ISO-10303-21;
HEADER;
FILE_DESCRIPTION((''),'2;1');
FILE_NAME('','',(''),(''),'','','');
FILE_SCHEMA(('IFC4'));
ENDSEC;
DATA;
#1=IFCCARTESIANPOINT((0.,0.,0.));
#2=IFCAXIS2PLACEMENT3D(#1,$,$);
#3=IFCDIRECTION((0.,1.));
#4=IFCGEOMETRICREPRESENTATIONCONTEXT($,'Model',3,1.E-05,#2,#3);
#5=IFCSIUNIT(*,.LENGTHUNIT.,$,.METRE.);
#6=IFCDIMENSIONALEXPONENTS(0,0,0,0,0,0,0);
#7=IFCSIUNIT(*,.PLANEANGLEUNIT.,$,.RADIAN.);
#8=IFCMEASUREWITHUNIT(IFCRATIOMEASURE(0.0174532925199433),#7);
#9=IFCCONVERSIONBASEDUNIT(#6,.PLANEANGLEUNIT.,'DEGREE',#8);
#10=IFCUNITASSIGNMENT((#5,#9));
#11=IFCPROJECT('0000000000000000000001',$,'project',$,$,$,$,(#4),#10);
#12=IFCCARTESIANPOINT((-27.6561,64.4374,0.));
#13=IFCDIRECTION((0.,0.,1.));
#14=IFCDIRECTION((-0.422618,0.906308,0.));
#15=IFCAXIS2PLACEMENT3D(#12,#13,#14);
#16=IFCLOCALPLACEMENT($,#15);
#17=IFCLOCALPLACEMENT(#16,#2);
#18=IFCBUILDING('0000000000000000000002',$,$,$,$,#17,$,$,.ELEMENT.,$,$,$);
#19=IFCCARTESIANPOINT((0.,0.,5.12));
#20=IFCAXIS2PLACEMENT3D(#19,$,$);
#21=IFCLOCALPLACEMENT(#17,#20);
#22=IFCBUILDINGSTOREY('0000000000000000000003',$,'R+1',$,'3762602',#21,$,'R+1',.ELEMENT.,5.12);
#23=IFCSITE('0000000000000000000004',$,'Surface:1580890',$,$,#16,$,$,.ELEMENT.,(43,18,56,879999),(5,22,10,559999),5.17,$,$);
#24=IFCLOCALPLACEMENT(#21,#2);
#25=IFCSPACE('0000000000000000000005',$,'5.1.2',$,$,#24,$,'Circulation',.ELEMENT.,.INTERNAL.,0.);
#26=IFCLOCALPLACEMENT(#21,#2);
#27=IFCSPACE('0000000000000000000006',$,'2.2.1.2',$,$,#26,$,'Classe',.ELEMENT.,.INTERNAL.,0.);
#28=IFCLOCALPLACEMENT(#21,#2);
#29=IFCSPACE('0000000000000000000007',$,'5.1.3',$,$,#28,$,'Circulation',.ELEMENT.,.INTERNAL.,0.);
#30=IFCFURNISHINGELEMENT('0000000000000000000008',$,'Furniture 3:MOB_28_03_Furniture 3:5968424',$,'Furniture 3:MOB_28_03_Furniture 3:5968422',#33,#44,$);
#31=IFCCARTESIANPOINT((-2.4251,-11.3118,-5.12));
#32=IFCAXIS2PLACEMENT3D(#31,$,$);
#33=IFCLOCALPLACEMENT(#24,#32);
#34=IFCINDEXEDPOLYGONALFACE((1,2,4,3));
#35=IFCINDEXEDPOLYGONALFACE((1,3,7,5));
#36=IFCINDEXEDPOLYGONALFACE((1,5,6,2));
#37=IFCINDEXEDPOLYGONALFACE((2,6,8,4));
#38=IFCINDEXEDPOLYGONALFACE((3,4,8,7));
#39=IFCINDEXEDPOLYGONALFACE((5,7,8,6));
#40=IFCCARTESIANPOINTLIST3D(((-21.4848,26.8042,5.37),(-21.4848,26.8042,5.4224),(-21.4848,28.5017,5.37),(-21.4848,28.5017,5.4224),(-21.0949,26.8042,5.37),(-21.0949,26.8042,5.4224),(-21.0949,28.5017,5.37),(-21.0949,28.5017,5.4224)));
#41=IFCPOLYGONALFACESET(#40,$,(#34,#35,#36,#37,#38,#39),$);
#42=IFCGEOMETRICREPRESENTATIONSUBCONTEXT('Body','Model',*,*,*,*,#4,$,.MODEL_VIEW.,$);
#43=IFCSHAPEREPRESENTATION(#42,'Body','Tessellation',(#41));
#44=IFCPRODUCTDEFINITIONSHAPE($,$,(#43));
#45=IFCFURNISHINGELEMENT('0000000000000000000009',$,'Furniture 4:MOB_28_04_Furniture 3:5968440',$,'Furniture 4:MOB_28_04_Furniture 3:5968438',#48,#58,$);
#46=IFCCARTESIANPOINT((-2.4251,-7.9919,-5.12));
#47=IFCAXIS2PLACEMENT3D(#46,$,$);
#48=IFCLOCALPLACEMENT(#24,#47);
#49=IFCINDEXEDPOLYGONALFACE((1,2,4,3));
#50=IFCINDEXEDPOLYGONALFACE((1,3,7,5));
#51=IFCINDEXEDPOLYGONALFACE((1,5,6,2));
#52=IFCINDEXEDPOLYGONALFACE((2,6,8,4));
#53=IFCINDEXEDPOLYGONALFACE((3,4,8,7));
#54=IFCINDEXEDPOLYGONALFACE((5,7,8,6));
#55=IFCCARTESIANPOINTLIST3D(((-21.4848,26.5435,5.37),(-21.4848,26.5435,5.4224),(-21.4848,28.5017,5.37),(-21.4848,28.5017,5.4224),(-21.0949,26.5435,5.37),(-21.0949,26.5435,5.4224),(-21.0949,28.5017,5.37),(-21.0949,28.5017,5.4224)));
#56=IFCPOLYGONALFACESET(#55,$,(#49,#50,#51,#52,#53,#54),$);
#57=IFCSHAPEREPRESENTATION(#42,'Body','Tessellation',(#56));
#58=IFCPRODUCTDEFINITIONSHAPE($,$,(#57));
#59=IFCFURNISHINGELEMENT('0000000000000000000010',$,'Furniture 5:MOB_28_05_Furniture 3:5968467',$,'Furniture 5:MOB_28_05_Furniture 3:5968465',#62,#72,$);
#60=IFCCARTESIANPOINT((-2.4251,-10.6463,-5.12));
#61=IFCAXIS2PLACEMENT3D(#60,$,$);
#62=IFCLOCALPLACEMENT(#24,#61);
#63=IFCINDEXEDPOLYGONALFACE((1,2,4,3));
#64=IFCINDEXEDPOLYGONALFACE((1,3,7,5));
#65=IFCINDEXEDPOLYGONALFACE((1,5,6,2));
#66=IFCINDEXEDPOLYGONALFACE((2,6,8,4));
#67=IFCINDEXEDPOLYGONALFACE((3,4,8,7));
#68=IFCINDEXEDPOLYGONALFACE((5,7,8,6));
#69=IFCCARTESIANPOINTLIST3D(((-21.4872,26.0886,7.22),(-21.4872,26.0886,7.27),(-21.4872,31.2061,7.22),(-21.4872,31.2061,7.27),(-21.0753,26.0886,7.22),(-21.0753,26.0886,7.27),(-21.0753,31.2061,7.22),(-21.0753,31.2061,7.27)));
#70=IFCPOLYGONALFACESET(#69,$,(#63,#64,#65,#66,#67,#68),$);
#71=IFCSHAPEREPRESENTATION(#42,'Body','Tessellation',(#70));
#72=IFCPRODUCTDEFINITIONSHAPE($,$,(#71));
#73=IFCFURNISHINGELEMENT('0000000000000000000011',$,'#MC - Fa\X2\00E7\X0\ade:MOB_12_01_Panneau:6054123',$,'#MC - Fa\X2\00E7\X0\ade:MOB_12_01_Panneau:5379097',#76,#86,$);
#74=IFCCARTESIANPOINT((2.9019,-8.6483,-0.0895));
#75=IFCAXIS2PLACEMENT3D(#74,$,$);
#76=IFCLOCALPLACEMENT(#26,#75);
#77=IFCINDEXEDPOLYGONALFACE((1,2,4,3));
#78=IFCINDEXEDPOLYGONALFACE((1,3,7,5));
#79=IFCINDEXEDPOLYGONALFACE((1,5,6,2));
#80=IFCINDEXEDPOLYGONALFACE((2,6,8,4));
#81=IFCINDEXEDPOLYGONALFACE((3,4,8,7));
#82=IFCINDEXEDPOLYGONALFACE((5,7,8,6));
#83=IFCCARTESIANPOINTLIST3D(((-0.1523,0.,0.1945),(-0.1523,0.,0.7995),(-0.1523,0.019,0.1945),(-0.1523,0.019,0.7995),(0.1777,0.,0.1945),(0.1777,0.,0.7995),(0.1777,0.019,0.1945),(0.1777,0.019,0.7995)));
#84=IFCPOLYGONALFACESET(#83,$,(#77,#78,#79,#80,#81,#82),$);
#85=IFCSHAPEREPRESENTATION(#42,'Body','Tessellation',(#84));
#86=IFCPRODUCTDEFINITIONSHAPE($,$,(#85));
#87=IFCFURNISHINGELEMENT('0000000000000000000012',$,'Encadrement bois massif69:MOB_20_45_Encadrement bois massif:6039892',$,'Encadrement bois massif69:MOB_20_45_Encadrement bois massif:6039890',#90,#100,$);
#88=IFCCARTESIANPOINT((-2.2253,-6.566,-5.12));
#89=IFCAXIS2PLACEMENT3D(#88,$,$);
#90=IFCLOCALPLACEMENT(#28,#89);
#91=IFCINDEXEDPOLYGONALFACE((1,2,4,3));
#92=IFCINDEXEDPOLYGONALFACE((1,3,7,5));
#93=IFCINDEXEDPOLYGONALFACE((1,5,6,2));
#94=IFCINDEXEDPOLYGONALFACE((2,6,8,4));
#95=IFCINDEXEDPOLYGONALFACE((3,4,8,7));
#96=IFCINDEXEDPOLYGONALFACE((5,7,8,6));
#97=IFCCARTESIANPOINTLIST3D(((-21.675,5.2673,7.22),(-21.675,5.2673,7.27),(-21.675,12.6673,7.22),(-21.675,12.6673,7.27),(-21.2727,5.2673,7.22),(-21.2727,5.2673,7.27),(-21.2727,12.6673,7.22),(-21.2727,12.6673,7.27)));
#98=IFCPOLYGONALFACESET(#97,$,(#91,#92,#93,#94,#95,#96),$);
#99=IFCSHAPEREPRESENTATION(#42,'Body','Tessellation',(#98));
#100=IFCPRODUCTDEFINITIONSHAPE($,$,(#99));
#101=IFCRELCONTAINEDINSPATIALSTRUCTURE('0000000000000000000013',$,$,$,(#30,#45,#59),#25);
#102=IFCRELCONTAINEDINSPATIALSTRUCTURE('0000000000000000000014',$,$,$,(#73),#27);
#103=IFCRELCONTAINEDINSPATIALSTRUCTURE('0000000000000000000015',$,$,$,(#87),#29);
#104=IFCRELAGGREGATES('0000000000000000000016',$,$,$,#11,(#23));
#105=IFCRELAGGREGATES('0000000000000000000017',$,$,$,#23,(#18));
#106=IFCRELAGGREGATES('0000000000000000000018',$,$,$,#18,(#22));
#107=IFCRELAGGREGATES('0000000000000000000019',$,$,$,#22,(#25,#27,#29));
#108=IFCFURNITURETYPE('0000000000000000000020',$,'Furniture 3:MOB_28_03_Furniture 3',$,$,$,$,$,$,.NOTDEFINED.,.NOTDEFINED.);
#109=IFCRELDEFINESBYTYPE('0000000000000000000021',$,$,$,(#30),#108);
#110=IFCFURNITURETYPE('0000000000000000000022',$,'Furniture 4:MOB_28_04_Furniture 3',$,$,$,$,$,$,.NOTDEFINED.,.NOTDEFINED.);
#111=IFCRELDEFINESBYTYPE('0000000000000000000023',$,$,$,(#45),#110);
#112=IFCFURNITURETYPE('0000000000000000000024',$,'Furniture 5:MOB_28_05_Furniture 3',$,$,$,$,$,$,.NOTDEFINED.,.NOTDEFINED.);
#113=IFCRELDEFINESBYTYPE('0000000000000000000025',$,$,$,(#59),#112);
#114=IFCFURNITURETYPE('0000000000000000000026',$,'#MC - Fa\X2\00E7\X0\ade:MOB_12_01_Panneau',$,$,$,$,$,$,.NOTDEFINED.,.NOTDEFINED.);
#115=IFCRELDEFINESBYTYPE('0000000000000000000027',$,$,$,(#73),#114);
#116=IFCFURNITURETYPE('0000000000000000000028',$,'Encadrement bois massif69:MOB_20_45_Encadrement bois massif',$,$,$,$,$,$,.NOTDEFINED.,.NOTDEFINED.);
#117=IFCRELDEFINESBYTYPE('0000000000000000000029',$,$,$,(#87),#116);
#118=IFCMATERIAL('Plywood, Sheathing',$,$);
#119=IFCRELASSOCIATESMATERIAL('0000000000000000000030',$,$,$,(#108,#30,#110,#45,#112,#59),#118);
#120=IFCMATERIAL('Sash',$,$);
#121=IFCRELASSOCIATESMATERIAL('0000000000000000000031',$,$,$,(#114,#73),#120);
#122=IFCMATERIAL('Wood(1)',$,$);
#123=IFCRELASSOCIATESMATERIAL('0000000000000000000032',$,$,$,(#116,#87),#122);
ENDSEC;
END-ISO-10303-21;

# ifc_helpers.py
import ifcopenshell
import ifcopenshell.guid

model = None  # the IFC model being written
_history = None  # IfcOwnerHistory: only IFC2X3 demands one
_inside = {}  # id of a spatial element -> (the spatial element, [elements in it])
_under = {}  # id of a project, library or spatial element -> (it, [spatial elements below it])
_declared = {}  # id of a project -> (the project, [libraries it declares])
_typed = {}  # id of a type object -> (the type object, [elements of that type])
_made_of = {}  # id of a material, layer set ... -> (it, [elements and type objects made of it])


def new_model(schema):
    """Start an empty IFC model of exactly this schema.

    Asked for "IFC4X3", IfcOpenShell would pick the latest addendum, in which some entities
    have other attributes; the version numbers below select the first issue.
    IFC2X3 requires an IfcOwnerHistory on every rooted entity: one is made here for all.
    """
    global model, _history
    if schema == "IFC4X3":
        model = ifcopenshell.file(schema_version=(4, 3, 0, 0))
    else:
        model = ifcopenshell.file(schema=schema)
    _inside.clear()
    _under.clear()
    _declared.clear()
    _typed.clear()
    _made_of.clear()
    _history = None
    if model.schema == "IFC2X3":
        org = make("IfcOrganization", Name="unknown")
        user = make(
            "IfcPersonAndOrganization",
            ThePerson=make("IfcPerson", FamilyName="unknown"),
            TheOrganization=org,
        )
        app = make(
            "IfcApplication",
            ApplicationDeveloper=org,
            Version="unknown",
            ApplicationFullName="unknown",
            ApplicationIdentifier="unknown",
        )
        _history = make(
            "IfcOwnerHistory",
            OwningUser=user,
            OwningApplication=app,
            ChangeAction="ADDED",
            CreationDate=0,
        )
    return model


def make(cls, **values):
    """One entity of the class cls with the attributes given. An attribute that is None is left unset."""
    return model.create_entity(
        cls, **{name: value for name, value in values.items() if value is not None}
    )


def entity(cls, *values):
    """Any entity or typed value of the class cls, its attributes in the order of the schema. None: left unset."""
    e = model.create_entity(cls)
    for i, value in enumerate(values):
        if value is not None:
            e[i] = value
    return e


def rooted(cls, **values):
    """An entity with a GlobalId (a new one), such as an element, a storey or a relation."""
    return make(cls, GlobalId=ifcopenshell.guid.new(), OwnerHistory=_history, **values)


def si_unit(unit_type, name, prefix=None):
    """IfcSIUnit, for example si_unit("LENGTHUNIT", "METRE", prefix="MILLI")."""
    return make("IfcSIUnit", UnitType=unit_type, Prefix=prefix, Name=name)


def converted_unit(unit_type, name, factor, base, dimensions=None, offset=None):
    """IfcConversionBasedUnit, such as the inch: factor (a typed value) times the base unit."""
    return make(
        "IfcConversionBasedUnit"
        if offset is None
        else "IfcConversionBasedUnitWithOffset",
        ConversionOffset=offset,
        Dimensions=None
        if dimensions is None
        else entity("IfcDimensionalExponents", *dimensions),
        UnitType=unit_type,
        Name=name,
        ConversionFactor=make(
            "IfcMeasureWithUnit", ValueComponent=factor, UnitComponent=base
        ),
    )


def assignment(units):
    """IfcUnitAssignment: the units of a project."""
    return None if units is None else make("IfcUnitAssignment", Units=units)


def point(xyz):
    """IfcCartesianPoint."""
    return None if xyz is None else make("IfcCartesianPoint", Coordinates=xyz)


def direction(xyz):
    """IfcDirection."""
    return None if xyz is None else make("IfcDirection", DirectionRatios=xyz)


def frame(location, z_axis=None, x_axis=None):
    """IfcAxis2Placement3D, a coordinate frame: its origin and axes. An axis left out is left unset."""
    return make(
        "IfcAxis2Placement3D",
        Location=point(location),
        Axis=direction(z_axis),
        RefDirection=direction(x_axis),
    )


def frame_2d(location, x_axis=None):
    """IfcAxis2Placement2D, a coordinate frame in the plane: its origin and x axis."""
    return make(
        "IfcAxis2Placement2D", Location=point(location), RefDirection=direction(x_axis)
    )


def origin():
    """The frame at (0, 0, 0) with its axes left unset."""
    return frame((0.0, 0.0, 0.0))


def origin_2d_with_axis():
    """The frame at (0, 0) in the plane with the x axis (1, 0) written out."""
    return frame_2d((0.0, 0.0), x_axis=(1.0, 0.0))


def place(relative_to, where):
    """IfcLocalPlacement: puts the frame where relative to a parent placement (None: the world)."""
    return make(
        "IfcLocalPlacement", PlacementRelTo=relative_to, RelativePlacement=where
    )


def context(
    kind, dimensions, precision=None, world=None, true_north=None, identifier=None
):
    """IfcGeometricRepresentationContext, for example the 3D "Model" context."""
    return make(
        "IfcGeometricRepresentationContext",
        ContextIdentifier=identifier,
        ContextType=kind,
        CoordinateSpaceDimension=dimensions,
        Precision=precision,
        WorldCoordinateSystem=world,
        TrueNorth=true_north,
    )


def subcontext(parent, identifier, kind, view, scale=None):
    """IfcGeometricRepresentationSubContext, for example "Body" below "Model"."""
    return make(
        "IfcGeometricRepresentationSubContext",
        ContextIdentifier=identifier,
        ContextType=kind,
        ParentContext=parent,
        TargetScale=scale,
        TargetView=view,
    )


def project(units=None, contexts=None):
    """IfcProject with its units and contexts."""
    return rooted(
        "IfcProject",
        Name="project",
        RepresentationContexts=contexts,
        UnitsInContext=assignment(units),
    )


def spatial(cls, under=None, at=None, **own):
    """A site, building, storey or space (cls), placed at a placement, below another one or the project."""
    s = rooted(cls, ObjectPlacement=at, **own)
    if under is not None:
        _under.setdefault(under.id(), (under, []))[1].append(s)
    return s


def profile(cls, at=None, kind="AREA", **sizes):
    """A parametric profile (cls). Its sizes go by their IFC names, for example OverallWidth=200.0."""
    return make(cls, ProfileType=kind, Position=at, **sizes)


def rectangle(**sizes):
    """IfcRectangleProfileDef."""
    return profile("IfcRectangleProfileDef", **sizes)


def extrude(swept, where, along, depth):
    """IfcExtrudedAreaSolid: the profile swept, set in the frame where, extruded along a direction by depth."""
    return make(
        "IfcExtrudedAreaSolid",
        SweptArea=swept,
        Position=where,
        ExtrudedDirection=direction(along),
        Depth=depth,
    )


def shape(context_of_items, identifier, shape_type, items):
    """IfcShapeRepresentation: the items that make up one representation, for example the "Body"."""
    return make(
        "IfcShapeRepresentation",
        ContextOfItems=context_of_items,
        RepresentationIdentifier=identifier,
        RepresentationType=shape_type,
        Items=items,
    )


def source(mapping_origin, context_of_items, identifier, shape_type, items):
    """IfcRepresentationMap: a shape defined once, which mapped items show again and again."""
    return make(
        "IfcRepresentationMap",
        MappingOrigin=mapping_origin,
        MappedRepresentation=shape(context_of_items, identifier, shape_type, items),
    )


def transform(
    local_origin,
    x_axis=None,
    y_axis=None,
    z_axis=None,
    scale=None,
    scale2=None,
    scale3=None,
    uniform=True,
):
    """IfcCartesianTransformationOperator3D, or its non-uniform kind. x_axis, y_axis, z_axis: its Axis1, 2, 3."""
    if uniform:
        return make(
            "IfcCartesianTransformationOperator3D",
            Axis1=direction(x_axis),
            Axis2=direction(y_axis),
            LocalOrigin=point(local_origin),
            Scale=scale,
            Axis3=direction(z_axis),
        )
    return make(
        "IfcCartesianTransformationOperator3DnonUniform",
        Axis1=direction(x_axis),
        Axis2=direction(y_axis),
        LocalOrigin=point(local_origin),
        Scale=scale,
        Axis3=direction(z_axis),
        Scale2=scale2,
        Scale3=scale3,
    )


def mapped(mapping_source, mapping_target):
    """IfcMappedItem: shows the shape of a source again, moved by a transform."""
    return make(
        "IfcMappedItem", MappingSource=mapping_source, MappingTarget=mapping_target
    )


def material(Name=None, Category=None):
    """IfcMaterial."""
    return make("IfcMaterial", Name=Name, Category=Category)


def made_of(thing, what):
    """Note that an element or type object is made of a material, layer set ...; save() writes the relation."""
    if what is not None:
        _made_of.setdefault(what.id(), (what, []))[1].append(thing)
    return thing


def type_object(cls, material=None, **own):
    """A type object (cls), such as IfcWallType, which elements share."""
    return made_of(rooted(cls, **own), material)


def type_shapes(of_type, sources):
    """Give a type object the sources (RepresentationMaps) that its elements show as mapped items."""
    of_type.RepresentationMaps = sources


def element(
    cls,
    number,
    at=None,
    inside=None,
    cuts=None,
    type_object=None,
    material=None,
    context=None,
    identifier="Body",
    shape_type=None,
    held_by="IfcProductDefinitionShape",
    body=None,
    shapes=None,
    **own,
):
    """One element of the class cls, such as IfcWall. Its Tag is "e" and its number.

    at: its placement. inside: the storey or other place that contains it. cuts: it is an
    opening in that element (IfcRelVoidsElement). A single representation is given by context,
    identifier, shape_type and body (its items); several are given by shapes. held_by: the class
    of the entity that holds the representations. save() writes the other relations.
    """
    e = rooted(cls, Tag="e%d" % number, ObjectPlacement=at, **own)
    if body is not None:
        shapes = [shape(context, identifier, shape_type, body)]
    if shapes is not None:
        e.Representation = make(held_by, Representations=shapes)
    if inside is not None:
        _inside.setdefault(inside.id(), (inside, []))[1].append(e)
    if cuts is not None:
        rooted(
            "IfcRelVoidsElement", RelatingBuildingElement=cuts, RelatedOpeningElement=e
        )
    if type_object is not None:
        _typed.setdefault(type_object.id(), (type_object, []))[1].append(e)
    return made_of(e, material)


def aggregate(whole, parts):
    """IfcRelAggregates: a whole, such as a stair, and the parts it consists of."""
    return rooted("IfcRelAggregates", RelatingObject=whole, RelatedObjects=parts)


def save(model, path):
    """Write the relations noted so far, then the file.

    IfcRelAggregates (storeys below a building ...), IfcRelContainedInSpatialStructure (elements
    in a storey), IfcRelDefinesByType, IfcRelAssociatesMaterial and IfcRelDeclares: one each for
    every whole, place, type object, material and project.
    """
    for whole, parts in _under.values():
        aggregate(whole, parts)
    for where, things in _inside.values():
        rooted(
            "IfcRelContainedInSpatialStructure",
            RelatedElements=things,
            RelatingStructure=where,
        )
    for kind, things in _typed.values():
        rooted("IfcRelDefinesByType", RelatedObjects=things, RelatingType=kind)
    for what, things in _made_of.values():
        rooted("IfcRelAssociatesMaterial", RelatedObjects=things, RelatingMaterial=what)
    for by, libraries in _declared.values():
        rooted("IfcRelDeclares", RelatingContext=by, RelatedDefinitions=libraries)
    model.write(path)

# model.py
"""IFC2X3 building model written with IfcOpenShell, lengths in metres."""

from ifc_helpers import new_model, entity, si_unit, converted_unit, direction, frame, frame_2d, origin, origin_2d_with_axis, place, context, subcontext, project, spatial, rectangle, extrude, source, transform, mapped, material, type_object, type_shapes, element, save


model = new_model("IFC2X3")

# Units and contexts
model_context = context("Model", 3, precision=1e-05, world=origin(), true_north=direction((0.0, 1.0)))
body_context = subcontext(model_context, "Body", "Model", "MODEL_VIEW")
ifc_project = project(units=[si_unit("LENGTHUNIT", "METRE"), converted_unit("PLANEANGLEUNIT", "DEGREE", entity("IfcRatioMeasure", 0.0174532925199433), si_unit("PLANEANGLEUNIT", "RADIAN"), dimensions=[0, 0, 0, 0, 0, 0, 0])], contexts=[model_context])

# Site, building, storey
site_placement = place(None, frame((-27.6561, 64.4374, 0.0), z_axis=(0.0, 0.0, 1.0), x_axis=(-0.422618, 0.906308, 0.0)))
site = spatial("IfcSite", under=ifc_project, at=site_placement, Name="Surface:1580890", CompositionType="ELEMENT", RefLatitude=(43, 18, 56, 879999), RefLongitude=(5, 22, 10, 559999), RefElevation=5.17)
building_placement = place(site_placement, origin())
building = spatial("IfcBuilding", under=site, at=building_placement, CompositionType="ELEMENT")
storey_placement = place(building_placement, frame((0.0, 0.0, 5.12)))
storey = spatial("IfcBuildingStorey", under=building, at=storey_placement, Name="R+1", ObjectType="3762602", LongName="R+1", CompositionType="ELEMENT", Elevation=5.12)

# Shared definitions
ifc_material_1 = material(Name="Sash")

# Shared definitions
ifc_material_2 = material(Name="Wood(1)")

# Shared definitions
space_1_placement = place(storey_placement, origin())
space_1 = spatial("IfcSpace", under=storey, at=space_1_placement, Name="5.1.2", LongName="Circulation", CompositionType="ELEMENT", InteriorOrExteriorSpace="INTERNAL", ElevationWithFlooring=0.0)

# Furnishing elements
ifc_material_3 = material(Name="Plywood, Sheathing")
furniture_type_1 = type_object("IfcFurnitureType", Name="Furniture 3:MOB_28_03_Furniture 3", material=ifc_material_3)
shared_shape_1 = source(origin(), body_context, "Body", "SweptSolid", [
    extrude(rectangle(XDim=1.6975, YDim=0.3899, at=origin_2d_with_axis()), frame((-21.2898, 27.6529, 5.37), z_axis=(0.0, 0.0, 1.0), x_axis=(0.0, -1.0, 0.0)), (0.0, 0.0, 1.0), 0.0524),
])
type_shapes(furniture_type_1, [shared_shape_1])
furnishing_1_placement = place(space_1_placement, frame((-2.4251, -11.3118, -5.12)))
element("IfcFurnishingElement", 1, at=furnishing_1_placement, inside=space_1, type_object=furniture_type_1, material=ifc_material_3, Name="Furniture 3:MOB_28_03_Furniture 3:5968424", ObjectType="Furniture 3:MOB_28_03_Furniture 3:5968422", context=body_context, shape_type="MappedRepresentation", body=[
    mapped(shared_shape_1, transform((0.0, 0.0, 0.0), scale=1.0)),
])
furniture_type_2 = type_object("IfcFurnitureType", Name="Furniture 4:MOB_28_04_Furniture 3", material=ifc_material_3)
shared_shape_2 = source(origin(), body_context, "Body", "SweptSolid", [
    extrude(rectangle(XDim=1.9582, YDim=0.3899, at=frame_2d((0.0, 0.0), x_axis=(1.0, 0.0))), frame((-21.2898, 27.5226, 5.37), z_axis=(0.0, 0.0, 1.0), x_axis=(0.0, -1.0, 0.0)), (0.0, 0.0, 1.0), 0.0524),
])
type_shapes(furniture_type_2, [shared_shape_2])
furnishing_2_placement = place(space_1_placement, frame((-2.4251, -7.9919, -5.12)))
element("IfcFurnishingElement", 2, at=furnishing_2_placement, inside=space_1, type_object=furniture_type_2, material=ifc_material_3, Name="Furniture 4:MOB_28_04_Furniture 3:5968440", ObjectType="Furniture 4:MOB_28_04_Furniture 3:5968438", context=body_context, shape_type="MappedRepresentation", body=[
    mapped(shared_shape_2, transform((0.0, 0.0, 0.0), scale=1.0)),
])
furniture_type_3 = type_object("IfcFurnitureType", Name="Furniture 5:MOB_28_05_Furniture 3", material=ifc_material_3)
shared_shape_3 = source(origin(), body_context, "Body", "SweptSolid", [
    extrude(rectangle(XDim=5.1174, YDim=0.4119, at=frame_2d((0.0, 0.0), x_axis=(1.0, 0.0))), frame((-21.2812, 28.6473, 7.22), z_axis=(0.0, 0.0, 1.0), x_axis=(0.0, -1.0, 0.0)), (0.0, 0.0, 1.0), 0.05),
])
type_shapes(furniture_type_3, [shared_shape_3])
furnishing_3_placement = place(space_1_placement, frame((-2.4251, -10.6463, -5.12)))
element("IfcFurnishingElement", 3, at=furnishing_3_placement, inside=space_1, type_object=furniture_type_3, material=ifc_material_3, Name="Furniture 5:MOB_28_05_Furniture 3:5968467", ObjectType="Furniture 5:MOB_28_05_Furniture 3:5968465", context=body_context, shape_type="MappedRepresentation", body=[
    mapped(shared_shape_3, transform((0.0, 0.0, 0.0), scale=1.0)),
])

# Shared definitions
space_2_placement = place(storey_placement, origin())
space_2 = spatial("IfcSpace", under=storey, at=space_2_placement, Name="2.2.1.2", LongName="Classe", CompositionType="ELEMENT", InteriorOrExteriorSpace="INTERNAL", ElevationWithFlooring=0.0)

# Furnishing element
furniture_type_4 = type_object("IfcFurnitureType", Name="#MC - Façade:MOB_12_01_Panneau", material=ifc_material_1)
shared_shape_4 = source(origin(), body_context, "Body", "SweptSolid", [
    extrude(rectangle(XDim=0.019, YDim=0.33, at=origin_2d_with_axis()), frame((0.0127, 0.0095, 0.1945), z_axis=(0.0, 0.0, 1.0), x_axis=(0.0, 1.0, 0.0)), (0.0, 0.0, 1.0), 0.605),
])
type_shapes(furniture_type_4, [shared_shape_4])
furnishing_4_placement = place(space_2_placement, frame((2.9019, -8.6483, -0.0895)))
element("IfcFurnishingElement", 4, at=furnishing_4_placement, inside=space_2, type_object=furniture_type_4, material=ifc_material_1, Name="#MC - Façade:MOB_12_01_Panneau:6054123", ObjectType="#MC - Façade:MOB_12_01_Panneau:5379097", context=body_context, shape_type="MappedRepresentation", body=[
    mapped(shared_shape_4, transform((0.0, 0.0, 0.0), scale=1.0)),
])

# Shared definitions
space_3_placement = place(storey_placement, origin())
space_3 = spatial("IfcSpace", under=storey, at=space_3_placement, Name="5.1.3", LongName="Circulation", CompositionType="ELEMENT", InteriorOrExteriorSpace="INTERNAL", ElevationWithFlooring=0.0)

# Furnishing element
furniture_type_5 = type_object("IfcFurnitureType", Name="Encadrement bois massif69:MOB_20_45_Encadrement bois massif", material=ifc_material_2)
shared_shape_5 = source(origin(), body_context, "Body", "SweptSolid", [
    extrude(rectangle(XDim=0.4023, YDim=7.4, at=frame_2d((0.0, 0.0), x_axis=(1.0, 0.0))), frame((-21.4739, 8.9673, 7.22), z_axis=(0.0, 0.0, 1.0), x_axis=(-1.0, 0.0, 0.0)), (0.0, 0.0, 1.0), 0.05),
])
type_shapes(furniture_type_5, [shared_shape_5])
furnishing_5_placement = place(space_3_placement, frame((-2.2253, -6.566, -5.12)))
element("IfcFurnishingElement", 5, at=furnishing_5_placement, inside=space_3, type_object=furniture_type_5, material=ifc_material_2, Name="Encadrement bois massif69:MOB_20_45_Encadrement bois massif:6039892", ObjectType="Encadrement bois massif69:MOB_20_45_Encadrement bois massif:6039890", context=body_context, shape_type="MappedRepresentation", body=[
    mapped(shared_shape_5, transform((0.0, 0.0, 0.0), scale=1.0)),
])

save(model, "model.ifc")
